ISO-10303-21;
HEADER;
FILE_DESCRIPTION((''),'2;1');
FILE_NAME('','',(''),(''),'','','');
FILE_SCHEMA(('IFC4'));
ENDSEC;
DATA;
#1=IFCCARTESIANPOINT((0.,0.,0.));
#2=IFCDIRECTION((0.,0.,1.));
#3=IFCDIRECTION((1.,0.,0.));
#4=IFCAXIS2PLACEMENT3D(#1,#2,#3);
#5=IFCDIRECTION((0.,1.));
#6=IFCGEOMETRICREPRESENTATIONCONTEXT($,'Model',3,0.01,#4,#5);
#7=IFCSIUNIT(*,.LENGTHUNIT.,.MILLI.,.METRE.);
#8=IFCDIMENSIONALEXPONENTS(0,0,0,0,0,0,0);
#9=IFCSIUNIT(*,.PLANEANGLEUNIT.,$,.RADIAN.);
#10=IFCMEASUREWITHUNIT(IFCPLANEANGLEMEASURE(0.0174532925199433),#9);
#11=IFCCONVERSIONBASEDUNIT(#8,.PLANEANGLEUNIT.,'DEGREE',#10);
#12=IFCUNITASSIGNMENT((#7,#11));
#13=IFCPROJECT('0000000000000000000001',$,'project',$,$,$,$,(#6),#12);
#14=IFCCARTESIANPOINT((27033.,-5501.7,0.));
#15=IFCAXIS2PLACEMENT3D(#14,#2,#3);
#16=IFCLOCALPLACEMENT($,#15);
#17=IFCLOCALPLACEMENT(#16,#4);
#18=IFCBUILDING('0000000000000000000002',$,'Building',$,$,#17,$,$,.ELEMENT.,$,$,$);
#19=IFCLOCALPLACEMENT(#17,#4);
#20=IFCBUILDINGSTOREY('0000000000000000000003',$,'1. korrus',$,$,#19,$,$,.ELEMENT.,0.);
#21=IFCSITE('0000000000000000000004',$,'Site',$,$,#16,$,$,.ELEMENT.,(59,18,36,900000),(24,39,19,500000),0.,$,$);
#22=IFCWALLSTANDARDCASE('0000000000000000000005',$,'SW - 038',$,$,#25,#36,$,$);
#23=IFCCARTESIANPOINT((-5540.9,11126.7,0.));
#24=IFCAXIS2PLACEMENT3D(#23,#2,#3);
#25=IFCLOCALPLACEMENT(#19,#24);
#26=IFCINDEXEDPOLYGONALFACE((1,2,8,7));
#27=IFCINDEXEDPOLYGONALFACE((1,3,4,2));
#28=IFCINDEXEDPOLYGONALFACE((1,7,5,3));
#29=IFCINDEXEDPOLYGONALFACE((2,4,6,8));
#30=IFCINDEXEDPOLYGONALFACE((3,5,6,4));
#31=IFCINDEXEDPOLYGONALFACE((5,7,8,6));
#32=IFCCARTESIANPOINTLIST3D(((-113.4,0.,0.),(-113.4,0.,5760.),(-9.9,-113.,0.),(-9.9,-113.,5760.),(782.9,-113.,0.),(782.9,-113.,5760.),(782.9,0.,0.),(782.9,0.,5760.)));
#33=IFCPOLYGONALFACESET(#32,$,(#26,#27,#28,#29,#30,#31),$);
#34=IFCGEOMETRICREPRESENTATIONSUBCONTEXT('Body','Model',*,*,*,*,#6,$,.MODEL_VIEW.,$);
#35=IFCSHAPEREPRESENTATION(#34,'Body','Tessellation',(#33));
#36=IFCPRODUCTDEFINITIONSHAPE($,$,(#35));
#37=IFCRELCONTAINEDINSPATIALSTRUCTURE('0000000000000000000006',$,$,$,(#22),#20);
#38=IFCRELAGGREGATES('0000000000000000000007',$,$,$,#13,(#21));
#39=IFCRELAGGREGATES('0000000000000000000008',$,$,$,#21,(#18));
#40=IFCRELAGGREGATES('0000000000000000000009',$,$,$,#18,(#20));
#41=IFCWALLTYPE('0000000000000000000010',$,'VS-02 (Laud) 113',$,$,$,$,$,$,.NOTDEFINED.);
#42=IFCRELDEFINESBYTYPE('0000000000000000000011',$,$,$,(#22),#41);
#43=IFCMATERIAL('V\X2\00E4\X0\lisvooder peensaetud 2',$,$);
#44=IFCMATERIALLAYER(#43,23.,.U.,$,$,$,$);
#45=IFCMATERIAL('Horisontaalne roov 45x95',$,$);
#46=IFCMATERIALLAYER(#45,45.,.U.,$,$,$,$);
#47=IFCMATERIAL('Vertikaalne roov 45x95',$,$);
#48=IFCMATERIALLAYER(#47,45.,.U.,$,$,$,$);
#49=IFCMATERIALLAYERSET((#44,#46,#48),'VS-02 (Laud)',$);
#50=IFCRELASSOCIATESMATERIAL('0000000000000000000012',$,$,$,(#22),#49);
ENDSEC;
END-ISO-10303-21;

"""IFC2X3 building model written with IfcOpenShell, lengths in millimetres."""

from ifc_helpers import new_model, entity, si_unit, converted_unit, direction, frame, origin_with_axes, place, context, subcontext, project, spatial, polyline, outline, extrude, material, layer, layer_set, layer_usage, type_object, element, save


model = new_model("IFC2X3")

# Units and contexts
model_context = context("Model", 3, precision=0.01, world=origin_with_axes(), true_north=direction((0.0, 1.0)))
body_context = subcontext(model_context, "Body", "Model", "MODEL_VIEW")
ifc_project = project(units=[si_unit("LENGTHUNIT", "METRE", prefix="MILLI"), converted_unit("PLANEANGLEUNIT", "DEGREE", entity("IfcPlaneAngleMeasure", 0.0174532925199433), si_unit("PLANEANGLEUNIT", "RADIAN"), dimensions=[0, 0, 0, 0, 0, 0, 0])], contexts=[model_context])

# Site, building, storey
site_placement = place(None, frame((27033.0, -5501.7, 0.0), z_axis=(0.0, 0.0, 1.0), x_axis=(1.0, 0.0, 0.0)))
site = spatial("IfcSite", under=ifc_project, at=site_placement, Name="Site", CompositionType="ELEMENT", RefLatitude=(59, 18, 36, 900000), RefLongitude=(24, 39, 19, 500000), RefElevation=0.0)
building_placement = place(site_placement, origin_with_axes())
building = spatial("IfcBuilding", under=site, at=building_placement, Name="Building", CompositionType="ELEMENT")
storey_placement = place(building_placement, origin_with_axes())
storey = spatial("IfcBuildingStorey", under=building, at=storey_placement, Name="1. korrus", CompositionType="ELEMENT", Elevation=0.0)

# Wall
ifc_material_1 = material(Name="Välisvooder peensaetud 2")
ifc_layer_1 = layer(ifc_material_1, 23.0, ventilated="UNKNOWN")
ifc_material_2 = material(Name="Horisontaalne roov 45x95")
ifc_layer_2 = layer(ifc_material_2, 45.0, ventilated="UNKNOWN")
ifc_material_3 = material(Name="Vertikaalne roov 45x95")
ifc_layer_3 = layer(ifc_material_3, 45.0, ventilated="UNKNOWN")
ifc_layer_set_1 = layer_set([ifc_layer_1, ifc_layer_2, ifc_layer_3], Name="VS-02 (Laud)")
wall_type_1 = type_object("IfcWallType", Name="VS-02 (Laud) 113", PredefinedType="NOTDEFINED")
ifc_layer_usage_1 = layer_usage(ifc_layer_set_1, "AXIS2", "POSITIVE", -113.0)
wall_1_placement = place(storey_placement, frame((-5540.9, 11126.7, 0.0), z_axis=(0.0, 0.0, 1.0), x_axis=(1.0, 0.0, 0.0)))
element("IfcWallStandardCase", 1, at=wall_1_placement, inside=storey, type_object=wall_type_1, material=ifc_layer_usage_1, Name="SW - 038", context=body_context, shape_type="SweptSolid", body=[
    extrude(outline(polyline([(-9.9, -113.0), (782.9, -113.0), (782.9, 0.0), (-113.4, 0.0), (-9.9, -113.0)])), origin_with_axes(), (0.0, 0.0, 1.0), 5760.0),
])

save(model, "model.ifc")
